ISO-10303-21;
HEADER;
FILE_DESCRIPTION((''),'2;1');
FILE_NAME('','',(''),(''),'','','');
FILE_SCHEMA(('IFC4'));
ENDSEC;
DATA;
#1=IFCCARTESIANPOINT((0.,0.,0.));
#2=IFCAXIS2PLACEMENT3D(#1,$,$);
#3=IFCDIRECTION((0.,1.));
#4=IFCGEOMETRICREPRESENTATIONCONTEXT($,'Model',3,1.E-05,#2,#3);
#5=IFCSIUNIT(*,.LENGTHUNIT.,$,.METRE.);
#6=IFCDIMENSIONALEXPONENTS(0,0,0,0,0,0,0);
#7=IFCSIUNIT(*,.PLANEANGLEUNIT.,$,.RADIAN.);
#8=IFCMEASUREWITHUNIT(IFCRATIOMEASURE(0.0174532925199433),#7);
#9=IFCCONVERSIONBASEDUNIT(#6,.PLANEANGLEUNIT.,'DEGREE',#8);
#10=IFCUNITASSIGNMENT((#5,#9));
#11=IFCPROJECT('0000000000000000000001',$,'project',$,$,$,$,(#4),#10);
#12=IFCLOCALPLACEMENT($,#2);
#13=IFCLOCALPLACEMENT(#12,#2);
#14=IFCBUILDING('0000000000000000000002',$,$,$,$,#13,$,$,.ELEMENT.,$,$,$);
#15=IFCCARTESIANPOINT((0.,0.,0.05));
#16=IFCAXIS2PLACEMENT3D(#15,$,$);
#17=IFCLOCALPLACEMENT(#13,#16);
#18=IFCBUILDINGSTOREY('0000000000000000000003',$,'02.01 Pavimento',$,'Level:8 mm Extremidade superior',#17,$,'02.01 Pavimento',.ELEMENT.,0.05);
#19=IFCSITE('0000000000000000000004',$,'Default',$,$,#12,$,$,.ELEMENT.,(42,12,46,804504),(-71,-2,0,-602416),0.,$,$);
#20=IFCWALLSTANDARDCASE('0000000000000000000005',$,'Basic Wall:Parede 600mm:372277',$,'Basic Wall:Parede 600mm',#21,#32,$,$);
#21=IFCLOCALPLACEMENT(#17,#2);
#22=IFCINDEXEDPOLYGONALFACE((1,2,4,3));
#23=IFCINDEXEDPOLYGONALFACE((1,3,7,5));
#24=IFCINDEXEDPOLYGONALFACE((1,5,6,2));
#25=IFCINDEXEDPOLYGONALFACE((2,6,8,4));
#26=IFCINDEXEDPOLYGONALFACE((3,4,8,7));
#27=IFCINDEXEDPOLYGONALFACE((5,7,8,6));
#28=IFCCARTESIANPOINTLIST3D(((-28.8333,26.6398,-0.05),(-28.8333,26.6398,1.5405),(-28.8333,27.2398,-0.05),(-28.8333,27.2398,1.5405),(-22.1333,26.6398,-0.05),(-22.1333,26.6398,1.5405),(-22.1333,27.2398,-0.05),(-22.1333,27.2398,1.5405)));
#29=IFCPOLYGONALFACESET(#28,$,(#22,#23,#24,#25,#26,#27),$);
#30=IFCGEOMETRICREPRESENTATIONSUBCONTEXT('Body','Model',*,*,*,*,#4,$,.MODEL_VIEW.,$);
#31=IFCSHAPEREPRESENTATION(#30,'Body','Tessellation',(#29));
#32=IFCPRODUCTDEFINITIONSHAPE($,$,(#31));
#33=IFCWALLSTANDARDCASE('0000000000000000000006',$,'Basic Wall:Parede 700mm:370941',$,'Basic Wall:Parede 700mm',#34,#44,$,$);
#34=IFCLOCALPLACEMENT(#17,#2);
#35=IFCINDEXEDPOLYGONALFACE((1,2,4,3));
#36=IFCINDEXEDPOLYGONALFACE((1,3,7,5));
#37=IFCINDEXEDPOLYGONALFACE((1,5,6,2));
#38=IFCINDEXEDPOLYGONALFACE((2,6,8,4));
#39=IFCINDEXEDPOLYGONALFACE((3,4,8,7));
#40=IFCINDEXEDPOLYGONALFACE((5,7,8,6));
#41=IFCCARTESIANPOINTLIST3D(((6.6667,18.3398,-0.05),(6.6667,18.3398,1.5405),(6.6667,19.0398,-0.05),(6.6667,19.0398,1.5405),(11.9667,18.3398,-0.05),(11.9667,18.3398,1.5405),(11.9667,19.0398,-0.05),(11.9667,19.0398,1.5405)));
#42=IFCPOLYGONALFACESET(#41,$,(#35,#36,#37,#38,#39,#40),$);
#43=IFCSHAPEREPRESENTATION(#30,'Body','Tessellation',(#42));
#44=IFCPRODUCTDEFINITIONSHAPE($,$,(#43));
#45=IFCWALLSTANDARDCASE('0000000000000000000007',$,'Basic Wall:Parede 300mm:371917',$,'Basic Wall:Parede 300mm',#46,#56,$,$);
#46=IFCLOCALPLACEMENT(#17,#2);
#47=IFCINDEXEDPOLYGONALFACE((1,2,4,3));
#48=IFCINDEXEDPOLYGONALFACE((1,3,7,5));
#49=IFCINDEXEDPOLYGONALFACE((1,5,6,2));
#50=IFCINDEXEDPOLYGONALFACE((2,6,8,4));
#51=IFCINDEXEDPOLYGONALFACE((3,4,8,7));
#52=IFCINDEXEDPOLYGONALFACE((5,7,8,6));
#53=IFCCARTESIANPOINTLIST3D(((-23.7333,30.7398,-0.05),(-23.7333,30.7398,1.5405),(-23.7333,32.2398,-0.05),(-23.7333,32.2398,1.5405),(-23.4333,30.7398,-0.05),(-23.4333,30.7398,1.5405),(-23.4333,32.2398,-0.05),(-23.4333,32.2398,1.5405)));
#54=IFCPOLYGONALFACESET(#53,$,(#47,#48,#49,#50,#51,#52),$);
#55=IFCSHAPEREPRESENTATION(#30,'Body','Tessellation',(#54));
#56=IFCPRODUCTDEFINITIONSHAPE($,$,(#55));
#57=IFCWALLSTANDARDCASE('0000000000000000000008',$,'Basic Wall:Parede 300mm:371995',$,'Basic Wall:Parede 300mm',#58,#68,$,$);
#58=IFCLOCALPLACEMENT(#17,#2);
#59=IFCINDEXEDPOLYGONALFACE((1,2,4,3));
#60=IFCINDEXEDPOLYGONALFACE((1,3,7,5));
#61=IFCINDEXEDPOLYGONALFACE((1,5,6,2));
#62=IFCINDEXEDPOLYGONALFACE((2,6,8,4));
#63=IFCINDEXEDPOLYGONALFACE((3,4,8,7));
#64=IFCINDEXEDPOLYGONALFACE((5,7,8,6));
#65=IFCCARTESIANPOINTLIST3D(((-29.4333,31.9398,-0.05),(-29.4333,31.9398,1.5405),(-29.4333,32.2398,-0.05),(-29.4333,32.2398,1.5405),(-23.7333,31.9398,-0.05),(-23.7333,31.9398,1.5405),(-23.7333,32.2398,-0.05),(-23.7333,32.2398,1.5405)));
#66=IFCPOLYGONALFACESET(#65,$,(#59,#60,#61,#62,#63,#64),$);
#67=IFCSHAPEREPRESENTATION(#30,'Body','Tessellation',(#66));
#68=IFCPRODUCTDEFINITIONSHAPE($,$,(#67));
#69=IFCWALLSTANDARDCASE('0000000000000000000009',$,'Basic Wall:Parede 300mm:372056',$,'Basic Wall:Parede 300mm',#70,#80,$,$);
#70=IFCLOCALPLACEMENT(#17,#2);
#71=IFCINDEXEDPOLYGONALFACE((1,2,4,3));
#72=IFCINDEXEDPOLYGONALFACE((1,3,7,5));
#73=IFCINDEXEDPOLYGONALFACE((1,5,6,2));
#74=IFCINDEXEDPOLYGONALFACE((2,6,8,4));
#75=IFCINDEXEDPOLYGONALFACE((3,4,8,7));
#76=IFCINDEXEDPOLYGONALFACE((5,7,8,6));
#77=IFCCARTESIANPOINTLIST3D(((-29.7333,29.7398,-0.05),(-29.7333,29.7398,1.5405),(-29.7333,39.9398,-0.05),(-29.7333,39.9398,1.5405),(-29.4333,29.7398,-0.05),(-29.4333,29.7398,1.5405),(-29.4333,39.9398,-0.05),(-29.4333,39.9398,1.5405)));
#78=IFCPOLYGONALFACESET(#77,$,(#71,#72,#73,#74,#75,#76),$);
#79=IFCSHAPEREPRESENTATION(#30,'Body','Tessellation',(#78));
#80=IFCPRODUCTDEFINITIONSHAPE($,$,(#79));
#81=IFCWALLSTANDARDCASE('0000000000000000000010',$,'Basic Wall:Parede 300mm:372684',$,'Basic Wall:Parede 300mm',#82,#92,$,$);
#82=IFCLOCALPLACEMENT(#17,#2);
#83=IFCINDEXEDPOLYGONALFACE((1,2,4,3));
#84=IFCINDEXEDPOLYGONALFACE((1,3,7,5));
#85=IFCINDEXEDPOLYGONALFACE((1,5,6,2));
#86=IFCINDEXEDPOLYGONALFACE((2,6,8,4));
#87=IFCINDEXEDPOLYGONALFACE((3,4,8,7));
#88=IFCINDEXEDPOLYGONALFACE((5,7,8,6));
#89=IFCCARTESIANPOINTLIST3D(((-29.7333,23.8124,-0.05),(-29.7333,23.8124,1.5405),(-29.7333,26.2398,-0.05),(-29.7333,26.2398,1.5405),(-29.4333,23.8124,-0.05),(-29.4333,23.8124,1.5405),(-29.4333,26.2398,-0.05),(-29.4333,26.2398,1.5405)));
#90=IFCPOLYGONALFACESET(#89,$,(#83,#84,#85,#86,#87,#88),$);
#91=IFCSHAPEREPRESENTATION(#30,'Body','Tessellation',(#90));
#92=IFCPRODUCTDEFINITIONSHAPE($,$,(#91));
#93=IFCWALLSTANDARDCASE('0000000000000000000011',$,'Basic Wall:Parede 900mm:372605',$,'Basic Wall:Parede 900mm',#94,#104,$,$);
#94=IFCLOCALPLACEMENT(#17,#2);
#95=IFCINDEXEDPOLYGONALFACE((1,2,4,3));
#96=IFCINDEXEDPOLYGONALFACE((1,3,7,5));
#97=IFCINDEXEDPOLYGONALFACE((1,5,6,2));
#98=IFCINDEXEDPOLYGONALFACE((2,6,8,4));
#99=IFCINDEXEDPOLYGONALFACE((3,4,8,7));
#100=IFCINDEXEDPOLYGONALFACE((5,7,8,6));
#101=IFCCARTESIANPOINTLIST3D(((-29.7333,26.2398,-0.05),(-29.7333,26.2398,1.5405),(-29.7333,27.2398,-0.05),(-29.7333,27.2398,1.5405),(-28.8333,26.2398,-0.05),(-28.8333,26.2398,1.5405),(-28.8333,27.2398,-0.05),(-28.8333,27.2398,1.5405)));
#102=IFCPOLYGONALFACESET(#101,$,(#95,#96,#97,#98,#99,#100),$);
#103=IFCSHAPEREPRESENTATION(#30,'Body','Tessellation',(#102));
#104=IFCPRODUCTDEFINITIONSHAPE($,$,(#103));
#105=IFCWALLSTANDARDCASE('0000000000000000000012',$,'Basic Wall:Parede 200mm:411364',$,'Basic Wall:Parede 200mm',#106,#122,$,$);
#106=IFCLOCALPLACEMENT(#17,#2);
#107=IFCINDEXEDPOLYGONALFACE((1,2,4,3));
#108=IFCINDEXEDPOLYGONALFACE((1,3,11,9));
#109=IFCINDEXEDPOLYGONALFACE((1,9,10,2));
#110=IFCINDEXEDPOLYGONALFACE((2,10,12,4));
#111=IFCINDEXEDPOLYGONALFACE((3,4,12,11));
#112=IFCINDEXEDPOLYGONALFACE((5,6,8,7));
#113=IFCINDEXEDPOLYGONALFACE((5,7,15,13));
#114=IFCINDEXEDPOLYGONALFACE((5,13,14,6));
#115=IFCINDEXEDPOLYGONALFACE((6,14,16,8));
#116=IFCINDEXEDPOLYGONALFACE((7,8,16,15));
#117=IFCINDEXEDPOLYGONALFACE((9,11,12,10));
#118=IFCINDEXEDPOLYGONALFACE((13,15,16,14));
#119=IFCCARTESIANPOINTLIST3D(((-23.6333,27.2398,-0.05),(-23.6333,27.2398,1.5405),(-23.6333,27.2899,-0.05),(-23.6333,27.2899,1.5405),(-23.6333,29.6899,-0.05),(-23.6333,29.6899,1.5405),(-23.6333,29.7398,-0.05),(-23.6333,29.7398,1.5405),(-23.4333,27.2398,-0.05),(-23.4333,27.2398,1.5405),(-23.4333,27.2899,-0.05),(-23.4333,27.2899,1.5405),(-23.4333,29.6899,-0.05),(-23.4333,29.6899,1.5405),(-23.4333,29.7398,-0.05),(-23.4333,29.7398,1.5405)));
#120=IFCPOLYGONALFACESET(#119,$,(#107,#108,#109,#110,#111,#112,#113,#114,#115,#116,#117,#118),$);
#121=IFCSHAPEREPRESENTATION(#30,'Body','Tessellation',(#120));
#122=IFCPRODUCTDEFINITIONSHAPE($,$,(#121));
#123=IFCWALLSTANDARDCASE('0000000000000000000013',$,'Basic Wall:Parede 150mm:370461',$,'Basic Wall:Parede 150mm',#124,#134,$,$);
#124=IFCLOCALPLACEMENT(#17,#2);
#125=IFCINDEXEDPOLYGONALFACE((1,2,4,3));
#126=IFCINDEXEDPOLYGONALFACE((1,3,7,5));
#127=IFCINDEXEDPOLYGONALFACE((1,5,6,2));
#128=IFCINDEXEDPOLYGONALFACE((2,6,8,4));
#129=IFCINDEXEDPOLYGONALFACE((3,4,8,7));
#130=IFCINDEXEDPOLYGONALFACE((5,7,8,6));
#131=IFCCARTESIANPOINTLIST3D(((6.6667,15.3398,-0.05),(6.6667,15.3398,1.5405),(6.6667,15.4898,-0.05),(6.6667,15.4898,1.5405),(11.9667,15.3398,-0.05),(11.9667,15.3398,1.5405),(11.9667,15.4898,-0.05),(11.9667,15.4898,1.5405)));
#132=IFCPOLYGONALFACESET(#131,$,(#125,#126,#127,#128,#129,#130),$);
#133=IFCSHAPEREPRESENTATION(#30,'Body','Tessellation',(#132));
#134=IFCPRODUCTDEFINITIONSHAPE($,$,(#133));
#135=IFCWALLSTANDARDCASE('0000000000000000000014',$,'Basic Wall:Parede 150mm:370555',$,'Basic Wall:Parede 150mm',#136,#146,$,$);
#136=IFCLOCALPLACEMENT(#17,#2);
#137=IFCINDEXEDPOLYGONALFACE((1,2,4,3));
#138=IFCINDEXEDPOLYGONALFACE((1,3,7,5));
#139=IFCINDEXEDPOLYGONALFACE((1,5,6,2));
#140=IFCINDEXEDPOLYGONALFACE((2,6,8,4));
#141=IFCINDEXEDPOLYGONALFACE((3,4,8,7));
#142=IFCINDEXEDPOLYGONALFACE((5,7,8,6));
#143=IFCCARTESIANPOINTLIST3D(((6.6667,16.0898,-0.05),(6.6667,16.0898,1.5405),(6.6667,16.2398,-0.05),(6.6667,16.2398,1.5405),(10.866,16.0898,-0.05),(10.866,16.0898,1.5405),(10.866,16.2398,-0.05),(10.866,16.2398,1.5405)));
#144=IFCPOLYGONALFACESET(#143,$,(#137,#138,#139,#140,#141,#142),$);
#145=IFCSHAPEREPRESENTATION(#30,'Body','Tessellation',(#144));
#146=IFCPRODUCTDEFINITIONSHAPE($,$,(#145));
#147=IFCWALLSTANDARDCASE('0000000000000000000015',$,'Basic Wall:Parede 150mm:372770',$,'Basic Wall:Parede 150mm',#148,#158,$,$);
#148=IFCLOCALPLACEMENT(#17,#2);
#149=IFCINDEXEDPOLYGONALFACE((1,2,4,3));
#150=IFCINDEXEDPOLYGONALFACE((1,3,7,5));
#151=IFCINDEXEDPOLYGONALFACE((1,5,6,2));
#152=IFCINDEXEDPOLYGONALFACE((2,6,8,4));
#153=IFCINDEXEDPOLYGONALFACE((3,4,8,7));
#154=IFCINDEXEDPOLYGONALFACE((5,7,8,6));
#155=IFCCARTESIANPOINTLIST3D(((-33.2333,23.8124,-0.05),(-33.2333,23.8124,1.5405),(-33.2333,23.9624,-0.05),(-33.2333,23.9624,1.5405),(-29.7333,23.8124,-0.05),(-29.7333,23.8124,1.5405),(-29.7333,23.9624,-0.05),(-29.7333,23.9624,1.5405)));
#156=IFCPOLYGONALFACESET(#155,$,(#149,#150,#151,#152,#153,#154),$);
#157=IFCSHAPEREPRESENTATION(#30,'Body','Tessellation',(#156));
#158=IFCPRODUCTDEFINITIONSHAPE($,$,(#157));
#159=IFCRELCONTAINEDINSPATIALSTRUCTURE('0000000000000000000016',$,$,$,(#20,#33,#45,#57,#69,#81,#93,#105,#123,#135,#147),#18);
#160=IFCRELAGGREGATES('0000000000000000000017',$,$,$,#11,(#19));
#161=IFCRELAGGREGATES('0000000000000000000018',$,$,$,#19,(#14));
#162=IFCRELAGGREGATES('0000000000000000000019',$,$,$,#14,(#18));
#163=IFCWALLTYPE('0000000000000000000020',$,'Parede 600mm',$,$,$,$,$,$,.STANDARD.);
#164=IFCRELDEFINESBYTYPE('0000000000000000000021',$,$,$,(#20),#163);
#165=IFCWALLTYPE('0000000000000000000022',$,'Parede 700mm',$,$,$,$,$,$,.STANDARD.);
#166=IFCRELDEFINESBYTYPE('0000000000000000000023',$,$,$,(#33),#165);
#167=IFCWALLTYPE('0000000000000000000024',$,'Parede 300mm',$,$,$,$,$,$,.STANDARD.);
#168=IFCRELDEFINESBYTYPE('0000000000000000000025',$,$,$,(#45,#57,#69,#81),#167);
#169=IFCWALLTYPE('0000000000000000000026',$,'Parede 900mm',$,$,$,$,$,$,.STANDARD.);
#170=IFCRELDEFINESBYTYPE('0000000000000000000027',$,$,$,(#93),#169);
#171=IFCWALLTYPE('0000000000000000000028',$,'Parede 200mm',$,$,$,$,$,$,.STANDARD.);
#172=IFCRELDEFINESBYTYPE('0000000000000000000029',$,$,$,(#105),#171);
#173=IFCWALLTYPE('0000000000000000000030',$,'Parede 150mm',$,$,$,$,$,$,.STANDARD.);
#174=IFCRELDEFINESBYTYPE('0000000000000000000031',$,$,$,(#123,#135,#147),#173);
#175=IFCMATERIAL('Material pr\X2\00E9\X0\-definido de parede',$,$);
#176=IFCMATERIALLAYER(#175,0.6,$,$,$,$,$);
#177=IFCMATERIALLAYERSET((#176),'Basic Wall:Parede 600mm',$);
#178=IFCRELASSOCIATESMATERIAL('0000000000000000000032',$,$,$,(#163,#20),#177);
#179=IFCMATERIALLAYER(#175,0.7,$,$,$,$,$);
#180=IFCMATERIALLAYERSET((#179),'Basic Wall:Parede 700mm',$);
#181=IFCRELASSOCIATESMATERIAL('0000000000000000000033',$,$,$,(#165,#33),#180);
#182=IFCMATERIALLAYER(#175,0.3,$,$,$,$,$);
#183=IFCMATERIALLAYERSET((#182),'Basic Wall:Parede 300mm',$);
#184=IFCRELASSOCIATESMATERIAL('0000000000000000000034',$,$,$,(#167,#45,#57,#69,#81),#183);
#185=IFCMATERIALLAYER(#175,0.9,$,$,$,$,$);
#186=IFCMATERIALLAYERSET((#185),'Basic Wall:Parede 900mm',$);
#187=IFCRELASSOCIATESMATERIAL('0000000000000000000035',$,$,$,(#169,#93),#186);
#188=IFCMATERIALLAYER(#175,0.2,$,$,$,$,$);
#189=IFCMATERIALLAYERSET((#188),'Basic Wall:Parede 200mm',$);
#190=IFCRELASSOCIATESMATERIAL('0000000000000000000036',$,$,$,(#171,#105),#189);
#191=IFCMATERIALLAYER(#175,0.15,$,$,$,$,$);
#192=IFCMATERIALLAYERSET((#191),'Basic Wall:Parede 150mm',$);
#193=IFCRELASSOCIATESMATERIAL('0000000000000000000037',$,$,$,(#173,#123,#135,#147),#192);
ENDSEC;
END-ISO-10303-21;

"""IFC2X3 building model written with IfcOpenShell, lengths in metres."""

from ifc_helpers import new_model, entity, si_unit, converted_unit, direction, frame, frame_2d, origin, place, context, subcontext, project, spatial, rectangle, extrude, clip, halfspace, material, layer, layer_set, layer_usage, type_object, element, save


model = new_model("IFC2X3")

# Units and contexts
model_context = context("Model", 3, precision=1e-05, world=origin(), true_north=direction((0.0, 1.0)))
body_context = subcontext(model_context, "Body", "Model", "MODEL_VIEW")
ifc_project = project(units=[si_unit("LENGTHUNIT", "METRE"), converted_unit("PLANEANGLEUNIT", "DEGREE", entity("IfcRatioMeasure", 0.0174532925199433), si_unit("PLANEANGLEUNIT", "RADIAN"), dimensions=[0, 0, 0, 0, 0, 0, 0])], contexts=[model_context])

# Site, building, storey
site_placement = place(None, origin())
site = spatial("IfcSite", under=ifc_project, at=site_placement, Name="Default", CompositionType="ELEMENT", RefLatitude=(42, 12, 46, 804504), RefLongitude=(-71, -2, 0, -602416), RefElevation=0.0)
building_placement = place(site_placement, origin())
building = spatial("IfcBuilding", under=site, at=building_placement, CompositionType="ELEMENT")
storey_placement = place(building_placement, frame((0.0, 0.0, 0.05)))
storey = spatial("IfcBuildingStorey", under=building, at=storey_placement, Name="02.01 Pavimento", ObjectType="Level:8 mm Extremidade superior", LongName="02.01 Pavimento", CompositionType="ELEMENT", Elevation=0.05)

# Shared definitions
ifc_material = material(Name="Material pré-definido de parede")

# Walls
ifc_layer_1 = layer(ifc_material, 0.6)
ifc_layer_set_1 = layer_set([ifc_layer_1], Name="Basic Wall:Parede 600mm")
ifc_layer_usage_1 = layer_usage(ifc_layer_set_1, "AXIS2", "POSITIVE", -0.3)
wall_type_1 = type_object("IfcWallType", Name="Parede 600mm", PredefinedType="STANDARD", material=ifc_layer_set_1)
wall_1_placement = place(storey_placement, frame((-22.1333, 26.9398, -0.05), z_axis=(0.0, 0.0, 1.0), x_axis=(-1.0, 0.0, 0.0)))
element("IfcWallStandardCase", 1, at=wall_1_placement, inside=storey, type_object=wall_type_1, material=ifc_layer_usage_1, Name="Basic Wall:Parede 600mm:372277", ObjectType="Basic Wall:Parede 600mm", context=body_context, shape_type="Clipping", body=[
    clip(extrude(rectangle(XDim=6.7, YDim=0.6, at=frame_2d((3.35, 0.0), x_axis=(-1.0, 0.0))), origin(), (0.0, 0.0, 1.0), 1.5905), halfspace(frame((0.0, 0.0, -0.05)), True)),
])
ifc_layer_2 = layer(ifc_material, 0.7)
ifc_layer_set_2 = layer_set([ifc_layer_2], Name="Basic Wall:Parede 700mm")
ifc_layer_usage_2 = layer_usage(ifc_layer_set_2, "AXIS2", "POSITIVE", -0.35)
wall_type_2 = type_object("IfcWallType", Name="Parede 700mm", PredefinedType="STANDARD", material=ifc_layer_set_2)
wall_2_placement = place(storey_placement, frame((6.6667, 18.6898, -0.05)))
element("IfcWallStandardCase", 2, at=wall_2_placement, inside=storey, type_object=wall_type_2, material=ifc_layer_usage_2, Name="Basic Wall:Parede 700mm:370941", ObjectType="Basic Wall:Parede 700mm", context=body_context, shape_type="Clipping", body=[
    clip(extrude(rectangle(XDim=0.7, YDim=5.3, at=frame_2d((2.65, 0.0), x_axis=(0.0, 1.0))), origin(), (0.0, 0.0, 1.0), 1.5905), halfspace(frame((0.0, 0.0, -0.05)), True)),
])
ifc_layer_3 = layer(ifc_material, 0.3)
ifc_layer_set_3 = layer_set([ifc_layer_3], Name="Basic Wall:Parede 300mm")
ifc_layer_usage_3 = layer_usage(ifc_layer_set_3, "AXIS2", "POSITIVE", -0.15)
wall_type_3 = type_object("IfcWallType", Name="Parede 300mm", PredefinedType="STANDARD", material=ifc_layer_set_3)
wall_3_placement = place(storey_placement, frame((-23.5833, 30.7398, -0.05), z_axis=(0.0, 0.0, 1.0), x_axis=(0.0, 1.0, 0.0)))
element("IfcWallStandardCase", 3, at=wall_3_placement, inside=storey, type_object=wall_type_3, material=ifc_layer_usage_3, Name="Basic Wall:Parede 300mm:371917", ObjectType="Basic Wall:Parede 300mm", context=body_context, shape_type="Clipping", body=[
    clip(extrude(rectangle(XDim=1.5, YDim=0.3, at=frame_2d((0.75, 0.0), x_axis=(-1.0, 0.0))), origin(), (0.0, 0.0, 1.0), 1.5905), halfspace(frame((0.0, 0.0, -0.05)), True)),
])
ifc_layer_usage_4 = layer_usage(ifc_layer_set_3, "AXIS2", "POSITIVE", -0.15)
wall_4_placement = place(storey_placement, frame((-23.7333, 32.0898, -0.05), z_axis=(0.0, 0.0, 1.0), x_axis=(-1.0, 0.0, 0.0)))
element("IfcWallStandardCase", 4, at=wall_4_placement, inside=storey, type_object=wall_type_3, material=ifc_layer_usage_4, Name="Basic Wall:Parede 300mm:371995", ObjectType="Basic Wall:Parede 300mm", context=body_context, shape_type="Clipping", body=[
    clip(extrude(rectangle(XDim=5.7, YDim=0.3, at=frame_2d((2.85, 0.0), x_axis=(-1.0, 0.0))), origin(), (0.0, 0.0, 1.0), 1.5905), halfspace(frame((0.0, 0.0, -0.05)), True)),
])
ifc_layer_usage_5 = layer_usage(ifc_layer_set_3, "AXIS2", "POSITIVE", -0.15)
wall_5_placement = place(storey_placement, frame((-29.5833, 39.9398, -0.05), z_axis=(0.0, 0.0, 1.0), x_axis=(0.0, -1.0, 0.0)))
element("IfcWallStandardCase", 5, at=wall_5_placement, inside=storey, type_object=wall_type_3, material=ifc_layer_usage_5, Name="Basic Wall:Parede 300mm:372056", ObjectType="Basic Wall:Parede 300mm", context=body_context, shape_type="Clipping", body=[
    clip(extrude(rectangle(XDim=10.2, YDim=0.3, at=frame_2d((5.1, 0.0), x_axis=(-1.0, 0.0))), origin(), (0.0, 0.0, 1.0), 1.5905), halfspace(frame((0.0, 0.0, -0.05)), True)),
])
ifc_layer_usage_6 = layer_usage(ifc_layer_set_3, "AXIS2", "POSITIVE", -0.15)
wall_6_placement = place(storey_placement, frame((-29.5833, 23.8124, -0.05), z_axis=(0.0, 0.0, 1.0), x_axis=(0.0, 1.0, 0.0)))
element("IfcWallStandardCase", 6, at=wall_6_placement, inside=storey, type_object=wall_type_3, material=ifc_layer_usage_6, Name="Basic Wall:Parede 300mm:372684", ObjectType="Basic Wall:Parede 300mm", context=body_context, shape_type="Clipping", body=[
    clip(extrude(rectangle(XDim=2.4275, YDim=0.3, at=frame_2d((1.2137, 0.0), x_axis=(-1.0, 0.0))), origin(), (0.0, 0.0, 1.0), 1.5905), halfspace(frame((0.0, 0.0, -0.05)), True)),
])

# Wall
ifc_layer_4 = layer(ifc_material, 0.9)
ifc_layer_set_4 = layer_set([ifc_layer_4], Name="Basic Wall:Parede 900mm")
ifc_layer_usage_7 = layer_usage(ifc_layer_set_4, "AXIS2", "POSITIVE", -0.45)
wall_type_4 = type_object("IfcWallType", Name="Parede 900mm", PredefinedType="STANDARD", material=ifc_layer_set_4)
wall_7_placement = place(storey_placement, frame((-29.2833, 26.2398, -0.05), z_axis=(0.0, 0.0, 1.0), x_axis=(0.0, 1.0, 0.0)))
element("IfcWallStandardCase", 7, at=wall_7_placement, inside=storey, type_object=wall_type_4, material=ifc_layer_usage_7, Name="Basic Wall:Parede 900mm:372605", ObjectType="Basic Wall:Parede 900mm", context=body_context, shape_type="Clipping", body=[
    clip(extrude(rectangle(XDim=1.0, YDim=0.9, at=frame_2d((0.5, 0.0), x_axis=(-1.0, 0.0))), origin(), (0.0, 0.0, 1.0), 1.5905), halfspace(frame((0.0, 0.0, -0.05)), True)),
])

# Wall, opening
ifc_layer_5 = layer(ifc_material, 0.2)
ifc_layer_set_5 = layer_set([ifc_layer_5], Name="Basic Wall:Parede 200mm")
ifc_layer_usage_8 = layer_usage(ifc_layer_set_5, "AXIS2", "NEGATIVE", 0.1)
wall_type_5 = type_object("IfcWallType", Name="Parede 200mm", PredefinedType="STANDARD", material=ifc_layer_set_5)
wall_8_placement = place(storey_placement, frame((-23.5333, 29.7398, -0.05), z_axis=(0.0, 0.0, 1.0), x_axis=(0.0, -1.0, 0.0)))
wall_8 = element("IfcWallStandardCase", 8, at=wall_8_placement, inside=storey, type_object=wall_type_5, material=ifc_layer_usage_8, Name="Basic Wall:Parede 200mm:411364", ObjectType="Basic Wall:Parede 200mm", context=body_context, shape_type="Clipping", body=[
    clip(extrude(rectangle(XDim=0.2, YDim=2.5, at=frame_2d((1.25, 0.0), x_axis=(0.0, 1.0))), origin(), (0.0, 0.0, 1.0), 1.5905), halfspace(frame((0.0, 0.0, -0.05)), True)),
])
opening_1_placement = place(wall_8_placement, frame((2.45, -1.624, 0.0), z_axis=(0.0, 0.0, 1.0), x_axis=(0.0, 1.0, 0.0)))
element("IfcOpeningElement", 9, at=opening_1_placement, cuts=wall_8, ObjectType="Opening", context=body_context, shape_type="SweptSolid", body=[
    extrude(rectangle(XDim=3.4, YDim=2.4, at=frame_2d((0.0, 0.0), x_axis=(1.0, 0.0))), frame((0.0, 1.2, 1.7), z_axis=(1.0, 0.0, 0.0), x_axis=(0.0, 0.0, 1.0)), (0.0, 0.0, 1.0), 3.048),
])

# Walls
ifc_layer_6 = layer(ifc_material, 0.15)
ifc_layer_set_6 = layer_set([ifc_layer_6], Name="Basic Wall:Parede 150mm")
ifc_layer_usage_9 = layer_usage(ifc_layer_set_6, "AXIS2", "POSITIVE", -0.075)
wall_type_6 = type_object("IfcWallType", Name="Parede 150mm", PredefinedType="STANDARD", material=ifc_layer_set_6)
wall_9_placement = place(storey_placement, frame((6.6667, 15.4148, -0.05)))
element("IfcWallStandardCase", 10, at=wall_9_placement, inside=storey, type_object=wall_type_6, material=ifc_layer_usage_9, Name="Basic Wall:Parede 150mm:370461", ObjectType="Basic Wall:Parede 150mm", context=body_context, shape_type="Clipping", body=[
    clip(extrude(rectangle(XDim=0.15, YDim=5.3, at=frame_2d((2.65, 0.0), x_axis=(0.0, 1.0))), origin(), (0.0, 0.0, 1.0), 1.5905), halfspace(frame((0.0, 0.0, -0.05)), True)),
])
ifc_layer_usage_10 = layer_usage(ifc_layer_set_6, "AXIS2", "POSITIVE", -0.075)
wall_10_placement = place(storey_placement, frame((6.6667, 16.1648, -0.05)))
element("IfcWallStandardCase", 11, at=wall_10_placement, inside=storey, type_object=wall_type_6, material=ifc_layer_usage_10, Name="Basic Wall:Parede 150mm:370555", ObjectType="Basic Wall:Parede 150mm", context=body_context, shape_type="Clipping", body=[
    clip(extrude(rectangle(XDim=4.1993, YDim=0.15, at=frame_2d((2.0997, 0.0), x_axis=(-1.0, 0.0))), origin(), (0.0, 0.0, 1.0), 1.5905), halfspace(frame((0.0, 0.0, -0.05)), True)),
])
ifc_layer_usage_11 = layer_usage(ifc_layer_set_6, "AXIS2", "NEGATIVE", 0.075)
wall_11_placement = place(storey_placement, frame((-29.7333, 23.8874, -0.05), z_axis=(0.0, 0.0, 1.0), x_axis=(-1.0, 0.0, 0.0)))
element("IfcWallStandardCase", 12, at=wall_11_placement, inside=storey, type_object=wall_type_6, material=ifc_layer_usage_11, Name="Basic Wall:Parede 150mm:372770", ObjectType="Basic Wall:Parede 150mm", context=body_context, shape_type="Clipping", body=[
    clip(extrude(rectangle(XDim=3.5, YDim=0.15, at=frame_2d((1.75, 0.0), x_axis=(-1.0, 0.0))), origin(), (0.0, 0.0, 1.0), 1.5905), halfspace(frame((0.0, 0.0, -0.05)), True)),
])

save(model, "model.ifc")
